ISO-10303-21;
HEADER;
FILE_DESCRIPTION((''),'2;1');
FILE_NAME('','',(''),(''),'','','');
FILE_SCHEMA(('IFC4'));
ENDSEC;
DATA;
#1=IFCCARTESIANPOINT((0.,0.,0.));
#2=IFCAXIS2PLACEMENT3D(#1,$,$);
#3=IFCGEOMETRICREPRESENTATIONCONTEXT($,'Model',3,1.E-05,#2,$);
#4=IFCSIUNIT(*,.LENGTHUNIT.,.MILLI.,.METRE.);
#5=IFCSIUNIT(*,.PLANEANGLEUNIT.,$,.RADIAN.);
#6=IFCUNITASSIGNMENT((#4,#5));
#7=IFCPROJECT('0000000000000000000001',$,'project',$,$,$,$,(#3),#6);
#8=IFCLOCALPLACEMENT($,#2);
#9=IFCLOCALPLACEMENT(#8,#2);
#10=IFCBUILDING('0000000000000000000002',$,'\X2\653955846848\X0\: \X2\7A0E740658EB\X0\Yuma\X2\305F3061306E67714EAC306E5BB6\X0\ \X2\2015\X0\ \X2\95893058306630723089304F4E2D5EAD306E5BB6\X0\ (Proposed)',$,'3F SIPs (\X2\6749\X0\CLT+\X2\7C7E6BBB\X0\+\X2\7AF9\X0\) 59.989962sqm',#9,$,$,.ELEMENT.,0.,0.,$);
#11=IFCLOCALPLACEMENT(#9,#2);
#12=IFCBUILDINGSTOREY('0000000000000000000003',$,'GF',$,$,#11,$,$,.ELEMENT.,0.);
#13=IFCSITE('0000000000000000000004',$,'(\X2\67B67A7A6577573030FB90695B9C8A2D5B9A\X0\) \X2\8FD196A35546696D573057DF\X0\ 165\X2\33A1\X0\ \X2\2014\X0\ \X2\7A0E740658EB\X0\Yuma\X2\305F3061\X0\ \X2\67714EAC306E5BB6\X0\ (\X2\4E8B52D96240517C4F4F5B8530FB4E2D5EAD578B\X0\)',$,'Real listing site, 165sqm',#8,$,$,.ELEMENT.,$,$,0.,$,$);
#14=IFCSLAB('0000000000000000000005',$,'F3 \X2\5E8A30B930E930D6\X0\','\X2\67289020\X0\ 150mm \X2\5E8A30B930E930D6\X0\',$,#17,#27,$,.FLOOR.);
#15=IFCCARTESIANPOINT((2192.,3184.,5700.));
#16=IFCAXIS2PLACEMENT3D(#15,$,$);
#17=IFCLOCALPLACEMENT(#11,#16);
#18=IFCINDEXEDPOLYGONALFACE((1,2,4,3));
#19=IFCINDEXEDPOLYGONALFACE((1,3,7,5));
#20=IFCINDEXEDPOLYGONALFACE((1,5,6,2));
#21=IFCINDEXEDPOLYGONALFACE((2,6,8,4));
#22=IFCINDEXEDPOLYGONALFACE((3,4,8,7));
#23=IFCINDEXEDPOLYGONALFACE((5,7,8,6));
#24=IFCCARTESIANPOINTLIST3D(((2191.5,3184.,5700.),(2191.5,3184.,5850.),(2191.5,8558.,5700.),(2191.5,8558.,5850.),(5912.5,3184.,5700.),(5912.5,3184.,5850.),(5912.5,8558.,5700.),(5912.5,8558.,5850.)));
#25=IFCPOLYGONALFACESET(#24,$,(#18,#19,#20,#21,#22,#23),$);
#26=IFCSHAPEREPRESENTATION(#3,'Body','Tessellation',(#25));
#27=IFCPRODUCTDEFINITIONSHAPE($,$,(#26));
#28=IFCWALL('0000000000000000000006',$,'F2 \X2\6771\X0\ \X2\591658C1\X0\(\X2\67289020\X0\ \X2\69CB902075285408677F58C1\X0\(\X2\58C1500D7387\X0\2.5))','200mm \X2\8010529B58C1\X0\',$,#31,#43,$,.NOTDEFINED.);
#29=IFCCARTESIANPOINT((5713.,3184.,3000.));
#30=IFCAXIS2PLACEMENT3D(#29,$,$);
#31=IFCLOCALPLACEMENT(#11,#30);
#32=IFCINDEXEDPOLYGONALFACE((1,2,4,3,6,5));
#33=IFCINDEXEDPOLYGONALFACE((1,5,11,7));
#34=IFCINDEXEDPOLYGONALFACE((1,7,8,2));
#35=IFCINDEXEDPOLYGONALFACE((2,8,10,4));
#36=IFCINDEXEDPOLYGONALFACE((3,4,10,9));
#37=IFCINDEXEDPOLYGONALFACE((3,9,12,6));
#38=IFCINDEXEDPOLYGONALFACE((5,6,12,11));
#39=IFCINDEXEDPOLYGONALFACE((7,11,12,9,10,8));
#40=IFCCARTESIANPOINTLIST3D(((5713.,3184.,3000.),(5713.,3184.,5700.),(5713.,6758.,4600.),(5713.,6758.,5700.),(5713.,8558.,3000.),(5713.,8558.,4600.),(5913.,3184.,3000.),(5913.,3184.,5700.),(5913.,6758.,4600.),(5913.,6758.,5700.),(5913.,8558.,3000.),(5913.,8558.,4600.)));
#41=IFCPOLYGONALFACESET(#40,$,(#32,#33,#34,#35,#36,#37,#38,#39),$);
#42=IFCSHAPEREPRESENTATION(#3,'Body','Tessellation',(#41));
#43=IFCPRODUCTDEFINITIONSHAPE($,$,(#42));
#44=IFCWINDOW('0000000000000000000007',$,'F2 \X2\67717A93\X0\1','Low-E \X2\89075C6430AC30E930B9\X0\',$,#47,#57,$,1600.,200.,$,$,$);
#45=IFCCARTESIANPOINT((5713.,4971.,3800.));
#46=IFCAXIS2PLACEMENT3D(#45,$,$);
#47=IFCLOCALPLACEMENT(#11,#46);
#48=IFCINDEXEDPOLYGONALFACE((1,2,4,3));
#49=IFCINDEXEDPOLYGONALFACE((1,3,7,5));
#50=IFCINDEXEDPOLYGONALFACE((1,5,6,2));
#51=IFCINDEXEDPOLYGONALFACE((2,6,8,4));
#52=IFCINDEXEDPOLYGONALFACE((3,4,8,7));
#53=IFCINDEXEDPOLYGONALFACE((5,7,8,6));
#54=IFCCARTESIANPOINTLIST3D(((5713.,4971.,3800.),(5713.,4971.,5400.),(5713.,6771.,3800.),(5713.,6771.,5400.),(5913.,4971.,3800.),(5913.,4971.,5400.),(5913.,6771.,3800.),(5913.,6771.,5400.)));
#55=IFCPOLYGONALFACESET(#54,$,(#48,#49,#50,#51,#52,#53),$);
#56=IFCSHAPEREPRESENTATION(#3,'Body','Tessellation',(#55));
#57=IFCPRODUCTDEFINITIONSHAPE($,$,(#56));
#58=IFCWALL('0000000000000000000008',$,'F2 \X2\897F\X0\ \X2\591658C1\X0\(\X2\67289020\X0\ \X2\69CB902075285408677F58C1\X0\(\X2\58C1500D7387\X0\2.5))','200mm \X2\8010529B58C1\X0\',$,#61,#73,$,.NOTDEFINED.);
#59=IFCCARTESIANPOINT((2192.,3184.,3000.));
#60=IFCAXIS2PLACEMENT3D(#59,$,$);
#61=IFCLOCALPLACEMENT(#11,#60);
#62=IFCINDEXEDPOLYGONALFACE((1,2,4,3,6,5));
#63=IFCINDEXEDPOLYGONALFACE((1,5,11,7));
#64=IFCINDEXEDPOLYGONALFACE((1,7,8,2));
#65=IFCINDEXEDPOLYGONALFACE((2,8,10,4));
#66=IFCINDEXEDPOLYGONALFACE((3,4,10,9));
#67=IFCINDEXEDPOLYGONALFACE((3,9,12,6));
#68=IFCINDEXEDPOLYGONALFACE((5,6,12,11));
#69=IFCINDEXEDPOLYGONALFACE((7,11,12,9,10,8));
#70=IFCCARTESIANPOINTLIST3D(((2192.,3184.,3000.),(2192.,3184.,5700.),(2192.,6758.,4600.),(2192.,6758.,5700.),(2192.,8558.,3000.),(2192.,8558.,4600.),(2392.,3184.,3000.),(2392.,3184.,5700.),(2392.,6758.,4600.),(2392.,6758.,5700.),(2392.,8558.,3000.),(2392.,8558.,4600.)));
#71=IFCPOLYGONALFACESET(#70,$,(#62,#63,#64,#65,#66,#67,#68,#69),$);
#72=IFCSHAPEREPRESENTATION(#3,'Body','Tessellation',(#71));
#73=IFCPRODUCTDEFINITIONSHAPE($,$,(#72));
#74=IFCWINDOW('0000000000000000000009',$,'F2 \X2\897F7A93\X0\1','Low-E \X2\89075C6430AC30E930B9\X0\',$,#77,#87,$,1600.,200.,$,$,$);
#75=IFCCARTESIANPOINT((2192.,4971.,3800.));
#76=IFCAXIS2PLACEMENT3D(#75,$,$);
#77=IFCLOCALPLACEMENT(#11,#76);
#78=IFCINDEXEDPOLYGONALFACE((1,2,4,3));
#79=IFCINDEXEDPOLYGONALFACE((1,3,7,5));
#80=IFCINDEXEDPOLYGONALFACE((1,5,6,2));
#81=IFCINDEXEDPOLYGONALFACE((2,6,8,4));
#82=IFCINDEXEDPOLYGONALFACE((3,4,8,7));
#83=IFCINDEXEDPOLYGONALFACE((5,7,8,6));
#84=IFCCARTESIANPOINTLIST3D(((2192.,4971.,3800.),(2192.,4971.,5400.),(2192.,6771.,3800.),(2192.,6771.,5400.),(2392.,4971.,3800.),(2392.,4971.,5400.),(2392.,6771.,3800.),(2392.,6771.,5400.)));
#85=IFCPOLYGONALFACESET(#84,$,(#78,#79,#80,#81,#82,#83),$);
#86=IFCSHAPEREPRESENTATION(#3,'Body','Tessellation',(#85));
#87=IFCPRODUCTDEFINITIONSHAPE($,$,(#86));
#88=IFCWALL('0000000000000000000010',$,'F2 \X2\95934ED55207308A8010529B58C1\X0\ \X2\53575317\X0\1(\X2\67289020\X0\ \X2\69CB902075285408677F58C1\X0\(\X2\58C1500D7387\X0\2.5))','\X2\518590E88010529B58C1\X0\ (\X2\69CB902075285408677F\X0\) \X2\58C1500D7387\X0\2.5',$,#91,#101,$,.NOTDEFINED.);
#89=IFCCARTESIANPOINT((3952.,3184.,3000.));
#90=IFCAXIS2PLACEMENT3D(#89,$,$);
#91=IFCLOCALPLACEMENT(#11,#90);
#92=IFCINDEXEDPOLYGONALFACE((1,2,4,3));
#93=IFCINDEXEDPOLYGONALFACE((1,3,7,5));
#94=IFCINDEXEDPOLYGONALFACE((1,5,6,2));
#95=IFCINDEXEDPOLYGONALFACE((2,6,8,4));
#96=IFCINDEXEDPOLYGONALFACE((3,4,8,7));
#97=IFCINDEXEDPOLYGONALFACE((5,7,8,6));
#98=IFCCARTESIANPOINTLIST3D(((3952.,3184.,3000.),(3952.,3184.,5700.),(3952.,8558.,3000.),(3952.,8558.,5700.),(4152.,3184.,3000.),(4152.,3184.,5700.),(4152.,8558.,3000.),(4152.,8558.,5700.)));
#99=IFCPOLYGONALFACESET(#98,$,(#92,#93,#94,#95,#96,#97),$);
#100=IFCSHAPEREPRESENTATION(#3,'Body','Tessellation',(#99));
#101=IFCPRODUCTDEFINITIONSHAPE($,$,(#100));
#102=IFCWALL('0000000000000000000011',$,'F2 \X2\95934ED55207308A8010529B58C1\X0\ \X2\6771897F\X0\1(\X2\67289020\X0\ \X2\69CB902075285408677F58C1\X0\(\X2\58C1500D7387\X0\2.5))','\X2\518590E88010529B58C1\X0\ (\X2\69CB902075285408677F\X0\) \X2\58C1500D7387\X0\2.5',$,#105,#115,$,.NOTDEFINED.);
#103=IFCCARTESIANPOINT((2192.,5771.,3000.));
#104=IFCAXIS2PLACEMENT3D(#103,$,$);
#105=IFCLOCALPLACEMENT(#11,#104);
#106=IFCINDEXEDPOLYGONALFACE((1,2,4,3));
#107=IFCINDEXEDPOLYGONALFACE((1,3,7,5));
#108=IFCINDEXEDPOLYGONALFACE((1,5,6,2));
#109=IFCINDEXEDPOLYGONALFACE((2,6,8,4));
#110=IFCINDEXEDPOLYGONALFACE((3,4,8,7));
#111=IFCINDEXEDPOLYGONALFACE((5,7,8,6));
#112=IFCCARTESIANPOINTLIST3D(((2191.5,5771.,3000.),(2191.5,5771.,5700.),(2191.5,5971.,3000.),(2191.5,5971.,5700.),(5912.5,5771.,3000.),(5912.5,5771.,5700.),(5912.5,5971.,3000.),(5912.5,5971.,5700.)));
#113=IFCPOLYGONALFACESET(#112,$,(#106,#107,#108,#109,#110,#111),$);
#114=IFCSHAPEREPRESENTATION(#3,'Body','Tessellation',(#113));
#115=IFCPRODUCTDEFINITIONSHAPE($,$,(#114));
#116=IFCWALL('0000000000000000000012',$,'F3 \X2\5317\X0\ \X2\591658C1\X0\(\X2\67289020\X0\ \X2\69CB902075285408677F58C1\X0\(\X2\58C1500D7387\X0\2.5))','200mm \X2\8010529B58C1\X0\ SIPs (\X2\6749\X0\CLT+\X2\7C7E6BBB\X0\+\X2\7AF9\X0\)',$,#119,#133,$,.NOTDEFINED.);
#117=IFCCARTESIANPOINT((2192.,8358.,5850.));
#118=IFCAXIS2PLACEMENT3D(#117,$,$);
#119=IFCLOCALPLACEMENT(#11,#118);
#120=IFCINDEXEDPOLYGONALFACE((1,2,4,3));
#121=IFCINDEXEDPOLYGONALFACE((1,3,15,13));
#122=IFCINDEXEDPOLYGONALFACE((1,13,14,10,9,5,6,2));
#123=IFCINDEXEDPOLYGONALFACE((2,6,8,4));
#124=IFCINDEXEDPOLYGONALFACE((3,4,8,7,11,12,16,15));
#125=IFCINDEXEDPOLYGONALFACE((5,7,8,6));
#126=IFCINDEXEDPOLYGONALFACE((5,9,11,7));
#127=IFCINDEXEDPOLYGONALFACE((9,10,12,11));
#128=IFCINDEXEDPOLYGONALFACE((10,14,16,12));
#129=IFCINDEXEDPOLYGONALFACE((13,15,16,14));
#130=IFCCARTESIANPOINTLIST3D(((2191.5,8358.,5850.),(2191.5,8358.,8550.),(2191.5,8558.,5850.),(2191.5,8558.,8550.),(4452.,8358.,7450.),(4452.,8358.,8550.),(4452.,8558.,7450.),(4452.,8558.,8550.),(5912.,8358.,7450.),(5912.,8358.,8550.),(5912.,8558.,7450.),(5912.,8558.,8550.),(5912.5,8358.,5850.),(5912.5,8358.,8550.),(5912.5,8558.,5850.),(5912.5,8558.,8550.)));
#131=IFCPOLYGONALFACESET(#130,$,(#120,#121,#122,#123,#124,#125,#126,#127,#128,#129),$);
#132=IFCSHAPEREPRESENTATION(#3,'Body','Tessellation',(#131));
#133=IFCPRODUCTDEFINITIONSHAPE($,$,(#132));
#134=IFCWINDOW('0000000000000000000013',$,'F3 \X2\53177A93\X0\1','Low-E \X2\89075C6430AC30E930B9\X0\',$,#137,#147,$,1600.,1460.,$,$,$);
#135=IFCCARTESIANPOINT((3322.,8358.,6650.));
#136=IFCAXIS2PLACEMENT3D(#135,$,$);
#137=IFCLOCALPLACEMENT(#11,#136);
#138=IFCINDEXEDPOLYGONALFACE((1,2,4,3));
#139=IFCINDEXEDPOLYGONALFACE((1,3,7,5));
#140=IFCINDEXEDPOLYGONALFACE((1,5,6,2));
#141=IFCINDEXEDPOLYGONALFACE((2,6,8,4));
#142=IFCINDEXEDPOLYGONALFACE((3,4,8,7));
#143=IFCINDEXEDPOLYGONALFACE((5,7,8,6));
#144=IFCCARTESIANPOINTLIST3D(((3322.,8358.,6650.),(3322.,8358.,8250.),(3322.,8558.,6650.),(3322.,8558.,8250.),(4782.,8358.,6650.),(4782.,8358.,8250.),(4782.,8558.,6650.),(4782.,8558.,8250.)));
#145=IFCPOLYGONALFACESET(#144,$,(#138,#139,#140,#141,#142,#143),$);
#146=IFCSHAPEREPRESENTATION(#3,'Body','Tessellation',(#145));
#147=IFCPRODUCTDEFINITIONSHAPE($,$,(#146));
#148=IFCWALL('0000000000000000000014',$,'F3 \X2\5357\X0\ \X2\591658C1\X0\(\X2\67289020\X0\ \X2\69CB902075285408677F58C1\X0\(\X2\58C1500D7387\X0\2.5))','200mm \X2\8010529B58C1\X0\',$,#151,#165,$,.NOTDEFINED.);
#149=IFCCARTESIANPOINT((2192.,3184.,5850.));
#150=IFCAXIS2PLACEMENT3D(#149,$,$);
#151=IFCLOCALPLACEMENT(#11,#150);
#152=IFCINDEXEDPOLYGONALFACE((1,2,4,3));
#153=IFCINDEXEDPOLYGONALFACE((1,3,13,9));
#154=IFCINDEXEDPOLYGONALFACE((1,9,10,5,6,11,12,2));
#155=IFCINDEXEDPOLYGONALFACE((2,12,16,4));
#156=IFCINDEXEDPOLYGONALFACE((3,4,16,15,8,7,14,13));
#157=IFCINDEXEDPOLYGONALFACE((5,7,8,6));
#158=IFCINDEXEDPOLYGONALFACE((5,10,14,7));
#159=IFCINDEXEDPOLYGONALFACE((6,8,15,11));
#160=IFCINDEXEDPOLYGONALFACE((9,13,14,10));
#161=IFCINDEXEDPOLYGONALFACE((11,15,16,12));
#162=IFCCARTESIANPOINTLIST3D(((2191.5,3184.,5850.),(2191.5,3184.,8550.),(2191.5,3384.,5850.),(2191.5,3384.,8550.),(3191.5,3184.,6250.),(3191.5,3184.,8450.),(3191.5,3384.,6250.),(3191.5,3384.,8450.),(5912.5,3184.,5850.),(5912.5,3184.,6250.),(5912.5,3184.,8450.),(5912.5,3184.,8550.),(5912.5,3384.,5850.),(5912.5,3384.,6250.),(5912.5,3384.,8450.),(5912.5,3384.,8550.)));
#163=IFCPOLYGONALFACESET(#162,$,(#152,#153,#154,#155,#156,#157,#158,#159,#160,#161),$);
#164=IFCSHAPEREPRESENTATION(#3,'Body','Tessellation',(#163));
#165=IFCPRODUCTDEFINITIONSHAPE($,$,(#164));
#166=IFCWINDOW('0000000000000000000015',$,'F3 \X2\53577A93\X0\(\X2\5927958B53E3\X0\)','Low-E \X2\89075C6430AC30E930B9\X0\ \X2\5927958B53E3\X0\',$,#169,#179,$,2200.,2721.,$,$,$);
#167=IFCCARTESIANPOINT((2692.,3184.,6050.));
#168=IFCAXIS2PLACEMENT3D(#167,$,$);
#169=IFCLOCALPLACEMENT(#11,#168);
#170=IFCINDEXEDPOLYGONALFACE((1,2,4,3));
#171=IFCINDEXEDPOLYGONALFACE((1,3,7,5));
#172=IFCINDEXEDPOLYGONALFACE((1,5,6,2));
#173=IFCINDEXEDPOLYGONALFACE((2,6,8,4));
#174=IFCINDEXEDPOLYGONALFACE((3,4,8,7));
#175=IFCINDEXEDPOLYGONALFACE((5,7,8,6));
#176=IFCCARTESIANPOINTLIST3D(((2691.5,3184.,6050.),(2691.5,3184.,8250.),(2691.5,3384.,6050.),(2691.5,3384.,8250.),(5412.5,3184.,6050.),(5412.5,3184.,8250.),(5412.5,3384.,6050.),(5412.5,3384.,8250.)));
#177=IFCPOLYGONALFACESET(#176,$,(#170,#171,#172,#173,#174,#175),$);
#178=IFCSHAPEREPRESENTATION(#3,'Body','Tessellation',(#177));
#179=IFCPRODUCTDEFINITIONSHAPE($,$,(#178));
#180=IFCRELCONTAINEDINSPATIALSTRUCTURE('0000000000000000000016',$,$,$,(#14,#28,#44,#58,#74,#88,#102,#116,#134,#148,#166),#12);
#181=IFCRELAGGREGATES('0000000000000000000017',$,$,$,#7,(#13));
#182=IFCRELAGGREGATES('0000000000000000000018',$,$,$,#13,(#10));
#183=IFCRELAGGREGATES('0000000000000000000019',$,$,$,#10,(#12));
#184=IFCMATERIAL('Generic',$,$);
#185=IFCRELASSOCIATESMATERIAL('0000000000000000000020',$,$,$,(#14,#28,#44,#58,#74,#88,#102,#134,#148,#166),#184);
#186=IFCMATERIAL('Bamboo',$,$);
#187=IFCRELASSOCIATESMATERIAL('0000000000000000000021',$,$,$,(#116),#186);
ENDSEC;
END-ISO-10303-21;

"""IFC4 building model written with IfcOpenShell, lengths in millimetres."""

from ifc_helpers import new_model, si_unit, frame, frame_2d, origin, place, context, project, spatial, rectangle, extrude, material, element, fill, save


model = new_model("IFC4")

# Units and contexts
model_context = context("Model", 3, precision=1e-05, world=origin())
ifc_project = project(units=[si_unit("LENGTHUNIT", "METRE", prefix="MILLI"), si_unit("PLANEANGLEUNIT", "RADIAN")], contexts=[model_context])

# Site, building, storey
site_placement = place(None, origin())
site = spatial("IfcSite", under=ifc_project, at=site_placement, Name="(架空敷地・適宜設定) 近隣商業地域 165㎡ — 税理士Yumaたち 東京の家 (事務所兼住宅・中庭型)", ObjectType="Real listing site, 165sqm", CompositionType="ELEMENT", RefElevation=0.0)
building_placement = place(site_placement, origin())
building = spatial("IfcBuilding", under=site, at=building_placement, Name="改善案: 税理士Yumaたちの東京の家 ― 閉じてひらく中庭の家 (Proposed)", ObjectType="3F SIPs (杉CLT+籾殻+竹) 59.989962sqm", CompositionType="ELEMENT", ElevationOfRefHeight=0.0, ElevationOfTerrain=0.0)
storey_placement = place(building_placement, origin())
storey = spatial("IfcBuildingStorey", under=building, at=storey_placement, Name="GF", CompositionType="ELEMENT", Elevation=0.0)

# Slab
ifc_material_1 = material(Name="Generic")
slab_placement = place(storey_placement, frame((2192.0, 3184.0, 5700.0)))
element("IfcSlab", 1, at=slab_placement, inside=storey, material=ifc_material_1, Name="F3 床スラブ", Description="木造 150mm 床スラブ", PredefinedType="FLOOR", context=model_context, shape_type="SweptSolid", body=[
    extrude(rectangle(XDim=3721.0, YDim=5374.0, at=frame_2d((1860.0, 2687.0))), frame((2192.0, 3184.0, 5700.0)), (0.0, 0.0, 1.0), 150.0),
])

# Walls, openings, windows
wall_1_placement = place(storey_placement, frame((5713.0, 3184.0, 3000.0)))
wall_1 = element("IfcWall", 2, at=wall_1_placement, inside=storey, material=ifc_material_1, Name="F2 東 外壁(木造 構造用合板壁(壁倍率2.5))", Description="200mm 耐力壁", PredefinedType="NOTDEFINED", context=model_context, shape_type="SweptSolid", body=[
    extrude(rectangle(XDim=200.0, YDim=5374.0, at=frame_2d((100.0, 2687.0))), frame((5713.0, 3184.0, 3000.0)), (0.0, 0.0, 1.0), 2700.0),
])
opening_1_placement = place(storey_placement, frame((5713.0, 4971.0, 3800.0)))
opening_1 = element("IfcOpeningElement", 3, at=opening_1_placement, cuts=wall_1, PredefinedType="NOTDEFINED", context=model_context, shape_type="SweptSolid", body=[
    extrude(rectangle(XDim=200.0, YDim=1800.0, at=frame_2d((100.0, 900.0))), frame((5713.0, 4971.0, 3800.0)), (0.0, 0.0, 1.0), 1600.0),
])
window_1_placement = place(storey_placement, frame((5713.0, 4971.0, 3800.0)))
window_1 = element("IfcWindow", 4, at=window_1_placement, inside=storey, material=ifc_material_1, Name="F2 東窓1", Description="Low-E 複層ガラス", OverallHeight=1600.0, OverallWidth=200.0, context=model_context, shape_type="SweptSolid", body=[
    extrude(rectangle(XDim=200.0, YDim=1800.0, at=frame_2d((100.0, 900.0))), frame((5713.0, 4971.0, 3800.0)), (0.0, 0.0, 1.0), 1600.0),
])
fill(opening_1, window_1)
wall_2_placement = place(storey_placement, frame((2192.0, 3184.0, 3000.0)))
wall_2 = element("IfcWall", 5, at=wall_2_placement, inside=storey, material=ifc_material_1, Name="F2 西 外壁(木造 構造用合板壁(壁倍率2.5))", Description="200mm 耐力壁", PredefinedType="NOTDEFINED", context=model_context, shape_type="SweptSolid", body=[
    extrude(rectangle(XDim=200.0, YDim=5374.0, at=frame_2d((100.0, 2687.0))), frame((2192.0, 3184.0, 3000.0)), (0.0, 0.0, 1.0), 2700.0),
])
opening_2_placement = place(storey_placement, frame((2192.0, 4971.0, 3800.0)))
opening_2 = element("IfcOpeningElement", 6, at=opening_2_placement, cuts=wall_2, PredefinedType="NOTDEFINED", context=model_context, shape_type="SweptSolid", body=[
    extrude(rectangle(XDim=200.0, YDim=1800.0, at=frame_2d((100.0, 900.0))), frame((2192.0, 4971.0, 3800.0)), (0.0, 0.0, 1.0), 1600.0),
])
window_2_placement = place(storey_placement, frame((2192.0, 4971.0, 3800.0)))
window_2 = element("IfcWindow", 7, at=window_2_placement, inside=storey, material=ifc_material_1, Name="F2 西窓1", Description="Low-E 複層ガラス", OverallHeight=1600.0, OverallWidth=200.0, context=model_context, shape_type="SweptSolid", body=[
    extrude(rectangle(XDim=200.0, YDim=1800.0, at=frame_2d((100.0, 900.0))), frame((2192.0, 4971.0, 3800.0)), (0.0, 0.0, 1.0), 1600.0),
])
fill(opening_2, window_2)

# Walls
wall_3_placement = place(storey_placement, frame((3952.0, 3184.0, 3000.0)))
element("IfcWall", 8, at=wall_3_placement, inside=storey, material=ifc_material_1, Name="F2 間仕切り耐力壁 南北1(木造 構造用合板壁(壁倍率2.5))", Description="内部耐力壁 (構造用合板) 壁倍率2.5", PredefinedType="NOTDEFINED", context=model_context, shape_type="SweptSolid", body=[
    extrude(rectangle(XDim=200.0, YDim=5374.0, at=frame_2d((100.0, 2687.0))), frame((3952.0, 3184.0, 3000.0)), (0.0, 0.0, 1.0), 2700.0),
])
wall_4_placement = place(storey_placement, frame((2192.0, 5771.0, 3000.0)))
element("IfcWall", 9, at=wall_4_placement, inside=storey, material=ifc_material_1, Name="F2 間仕切り耐力壁 東西1(木造 構造用合板壁(壁倍率2.5))", Description="内部耐力壁 (構造用合板) 壁倍率2.5", PredefinedType="NOTDEFINED", context=model_context, shape_type="SweptSolid", body=[
    extrude(rectangle(XDim=3721.0, YDim=200.0, at=frame_2d((1860.0, 100.0))), frame((2192.0, 5771.0, 3000.0)), (0.0, 0.0, 1.0), 2700.0),
])

# Walls, openings, windows
ifc_material_2 = material(Name="Bamboo")
wall_5_placement = place(storey_placement, frame((2192.0, 8358.0, 5850.0)))
wall_5 = element("IfcWall", 10, at=wall_5_placement, inside=storey, material=ifc_material_2, Name="F3 北 外壁(木造 構造用合板壁(壁倍率2.5))", Description="200mm 耐力壁 SIPs (杉CLT+籾殻+竹)", PredefinedType="NOTDEFINED", context=model_context, shape_type="SweptSolid", body=[
    extrude(rectangle(XDim=3721.0, YDim=200.0, at=frame_2d((1860.0, 100.0))), frame((2192.0, 8358.0, 5850.0)), (0.0, 0.0, 1.0), 2700.0),
])
opening_3_placement = place(storey_placement, frame((3322.0, 8358.0, 6650.0)))
opening_3 = element("IfcOpeningElement", 11, at=opening_3_placement, cuts=wall_5, PredefinedType="NOTDEFINED", context=model_context, shape_type="SweptSolid", body=[
    extrude(rectangle(XDim=1460.0, YDim=200.0, at=frame_2d((730.0, 100.0))), frame((3322.0, 8358.0, 6650.0)), (0.0, 0.0, 1.0), 1600.0),
])
window_3_placement = place(storey_placement, frame((3322.0, 8358.0, 6650.0)))
window_3 = element("IfcWindow", 12, at=window_3_placement, inside=storey, material=ifc_material_1, Name="F3 北窓1", Description="Low-E 複層ガラス", OverallHeight=1600.0, OverallWidth=1460.0, context=model_context, shape_type="SweptSolid", body=[
    extrude(rectangle(XDim=1460.0, YDim=200.0, at=frame_2d((730.0, 100.0))), frame((3322.0, 8358.0, 6650.0)), (0.0, 0.0, 1.0), 1600.0),
])
fill(opening_3, window_3)
wall_6_placement = place(storey_placement, frame((2192.0, 3184.0, 5850.0)))
wall_6 = element("IfcWall", 13, at=wall_6_placement, inside=storey, material=ifc_material_1, Name="F3 南 外壁(木造 構造用合板壁(壁倍率2.5))", Description="200mm 耐力壁", PredefinedType="NOTDEFINED", context=model_context, shape_type="SweptSolid", body=[
    extrude(rectangle(XDim=3721.0, YDim=200.0, at=frame_2d((1860.0, 100.0))), frame((2192.0, 3184.0, 5850.0)), (0.0, 0.0, 1.0), 2700.0),
])
opening_4_placement = place(storey_placement, frame((2692.0, 3184.0, 6050.0)))
opening_4 = element("IfcOpeningElement", 14, at=opening_4_placement, cuts=wall_6, PredefinedType="NOTDEFINED", context=model_context, shape_type="SweptSolid", body=[
    extrude(rectangle(XDim=2721.0, YDim=200.0, at=frame_2d((1360.0, 100.0))), frame((2692.0, 3184.0, 6050.0)), (0.0, 0.0, 1.0), 2200.0),
])
window_4_placement = place(storey_placement, frame((2692.0, 3184.0, 6050.0)))
window_4 = element("IfcWindow", 15, at=window_4_placement, inside=storey, material=ifc_material_1, Name="F3 南窓(大開口)", Description="Low-E 複層ガラス 大開口", OverallHeight=2200.0, OverallWidth=2721.0, context=model_context, shape_type="SweptSolid", body=[
    extrude(rectangle(XDim=2721.0, YDim=200.0, at=frame_2d((1360.0, 100.0))), frame((2692.0, 3184.0, 6050.0)), (0.0, 0.0, 1.0), 2200.0),
])
fill(opening_4, window_4)

save(model, "model.ifc")
